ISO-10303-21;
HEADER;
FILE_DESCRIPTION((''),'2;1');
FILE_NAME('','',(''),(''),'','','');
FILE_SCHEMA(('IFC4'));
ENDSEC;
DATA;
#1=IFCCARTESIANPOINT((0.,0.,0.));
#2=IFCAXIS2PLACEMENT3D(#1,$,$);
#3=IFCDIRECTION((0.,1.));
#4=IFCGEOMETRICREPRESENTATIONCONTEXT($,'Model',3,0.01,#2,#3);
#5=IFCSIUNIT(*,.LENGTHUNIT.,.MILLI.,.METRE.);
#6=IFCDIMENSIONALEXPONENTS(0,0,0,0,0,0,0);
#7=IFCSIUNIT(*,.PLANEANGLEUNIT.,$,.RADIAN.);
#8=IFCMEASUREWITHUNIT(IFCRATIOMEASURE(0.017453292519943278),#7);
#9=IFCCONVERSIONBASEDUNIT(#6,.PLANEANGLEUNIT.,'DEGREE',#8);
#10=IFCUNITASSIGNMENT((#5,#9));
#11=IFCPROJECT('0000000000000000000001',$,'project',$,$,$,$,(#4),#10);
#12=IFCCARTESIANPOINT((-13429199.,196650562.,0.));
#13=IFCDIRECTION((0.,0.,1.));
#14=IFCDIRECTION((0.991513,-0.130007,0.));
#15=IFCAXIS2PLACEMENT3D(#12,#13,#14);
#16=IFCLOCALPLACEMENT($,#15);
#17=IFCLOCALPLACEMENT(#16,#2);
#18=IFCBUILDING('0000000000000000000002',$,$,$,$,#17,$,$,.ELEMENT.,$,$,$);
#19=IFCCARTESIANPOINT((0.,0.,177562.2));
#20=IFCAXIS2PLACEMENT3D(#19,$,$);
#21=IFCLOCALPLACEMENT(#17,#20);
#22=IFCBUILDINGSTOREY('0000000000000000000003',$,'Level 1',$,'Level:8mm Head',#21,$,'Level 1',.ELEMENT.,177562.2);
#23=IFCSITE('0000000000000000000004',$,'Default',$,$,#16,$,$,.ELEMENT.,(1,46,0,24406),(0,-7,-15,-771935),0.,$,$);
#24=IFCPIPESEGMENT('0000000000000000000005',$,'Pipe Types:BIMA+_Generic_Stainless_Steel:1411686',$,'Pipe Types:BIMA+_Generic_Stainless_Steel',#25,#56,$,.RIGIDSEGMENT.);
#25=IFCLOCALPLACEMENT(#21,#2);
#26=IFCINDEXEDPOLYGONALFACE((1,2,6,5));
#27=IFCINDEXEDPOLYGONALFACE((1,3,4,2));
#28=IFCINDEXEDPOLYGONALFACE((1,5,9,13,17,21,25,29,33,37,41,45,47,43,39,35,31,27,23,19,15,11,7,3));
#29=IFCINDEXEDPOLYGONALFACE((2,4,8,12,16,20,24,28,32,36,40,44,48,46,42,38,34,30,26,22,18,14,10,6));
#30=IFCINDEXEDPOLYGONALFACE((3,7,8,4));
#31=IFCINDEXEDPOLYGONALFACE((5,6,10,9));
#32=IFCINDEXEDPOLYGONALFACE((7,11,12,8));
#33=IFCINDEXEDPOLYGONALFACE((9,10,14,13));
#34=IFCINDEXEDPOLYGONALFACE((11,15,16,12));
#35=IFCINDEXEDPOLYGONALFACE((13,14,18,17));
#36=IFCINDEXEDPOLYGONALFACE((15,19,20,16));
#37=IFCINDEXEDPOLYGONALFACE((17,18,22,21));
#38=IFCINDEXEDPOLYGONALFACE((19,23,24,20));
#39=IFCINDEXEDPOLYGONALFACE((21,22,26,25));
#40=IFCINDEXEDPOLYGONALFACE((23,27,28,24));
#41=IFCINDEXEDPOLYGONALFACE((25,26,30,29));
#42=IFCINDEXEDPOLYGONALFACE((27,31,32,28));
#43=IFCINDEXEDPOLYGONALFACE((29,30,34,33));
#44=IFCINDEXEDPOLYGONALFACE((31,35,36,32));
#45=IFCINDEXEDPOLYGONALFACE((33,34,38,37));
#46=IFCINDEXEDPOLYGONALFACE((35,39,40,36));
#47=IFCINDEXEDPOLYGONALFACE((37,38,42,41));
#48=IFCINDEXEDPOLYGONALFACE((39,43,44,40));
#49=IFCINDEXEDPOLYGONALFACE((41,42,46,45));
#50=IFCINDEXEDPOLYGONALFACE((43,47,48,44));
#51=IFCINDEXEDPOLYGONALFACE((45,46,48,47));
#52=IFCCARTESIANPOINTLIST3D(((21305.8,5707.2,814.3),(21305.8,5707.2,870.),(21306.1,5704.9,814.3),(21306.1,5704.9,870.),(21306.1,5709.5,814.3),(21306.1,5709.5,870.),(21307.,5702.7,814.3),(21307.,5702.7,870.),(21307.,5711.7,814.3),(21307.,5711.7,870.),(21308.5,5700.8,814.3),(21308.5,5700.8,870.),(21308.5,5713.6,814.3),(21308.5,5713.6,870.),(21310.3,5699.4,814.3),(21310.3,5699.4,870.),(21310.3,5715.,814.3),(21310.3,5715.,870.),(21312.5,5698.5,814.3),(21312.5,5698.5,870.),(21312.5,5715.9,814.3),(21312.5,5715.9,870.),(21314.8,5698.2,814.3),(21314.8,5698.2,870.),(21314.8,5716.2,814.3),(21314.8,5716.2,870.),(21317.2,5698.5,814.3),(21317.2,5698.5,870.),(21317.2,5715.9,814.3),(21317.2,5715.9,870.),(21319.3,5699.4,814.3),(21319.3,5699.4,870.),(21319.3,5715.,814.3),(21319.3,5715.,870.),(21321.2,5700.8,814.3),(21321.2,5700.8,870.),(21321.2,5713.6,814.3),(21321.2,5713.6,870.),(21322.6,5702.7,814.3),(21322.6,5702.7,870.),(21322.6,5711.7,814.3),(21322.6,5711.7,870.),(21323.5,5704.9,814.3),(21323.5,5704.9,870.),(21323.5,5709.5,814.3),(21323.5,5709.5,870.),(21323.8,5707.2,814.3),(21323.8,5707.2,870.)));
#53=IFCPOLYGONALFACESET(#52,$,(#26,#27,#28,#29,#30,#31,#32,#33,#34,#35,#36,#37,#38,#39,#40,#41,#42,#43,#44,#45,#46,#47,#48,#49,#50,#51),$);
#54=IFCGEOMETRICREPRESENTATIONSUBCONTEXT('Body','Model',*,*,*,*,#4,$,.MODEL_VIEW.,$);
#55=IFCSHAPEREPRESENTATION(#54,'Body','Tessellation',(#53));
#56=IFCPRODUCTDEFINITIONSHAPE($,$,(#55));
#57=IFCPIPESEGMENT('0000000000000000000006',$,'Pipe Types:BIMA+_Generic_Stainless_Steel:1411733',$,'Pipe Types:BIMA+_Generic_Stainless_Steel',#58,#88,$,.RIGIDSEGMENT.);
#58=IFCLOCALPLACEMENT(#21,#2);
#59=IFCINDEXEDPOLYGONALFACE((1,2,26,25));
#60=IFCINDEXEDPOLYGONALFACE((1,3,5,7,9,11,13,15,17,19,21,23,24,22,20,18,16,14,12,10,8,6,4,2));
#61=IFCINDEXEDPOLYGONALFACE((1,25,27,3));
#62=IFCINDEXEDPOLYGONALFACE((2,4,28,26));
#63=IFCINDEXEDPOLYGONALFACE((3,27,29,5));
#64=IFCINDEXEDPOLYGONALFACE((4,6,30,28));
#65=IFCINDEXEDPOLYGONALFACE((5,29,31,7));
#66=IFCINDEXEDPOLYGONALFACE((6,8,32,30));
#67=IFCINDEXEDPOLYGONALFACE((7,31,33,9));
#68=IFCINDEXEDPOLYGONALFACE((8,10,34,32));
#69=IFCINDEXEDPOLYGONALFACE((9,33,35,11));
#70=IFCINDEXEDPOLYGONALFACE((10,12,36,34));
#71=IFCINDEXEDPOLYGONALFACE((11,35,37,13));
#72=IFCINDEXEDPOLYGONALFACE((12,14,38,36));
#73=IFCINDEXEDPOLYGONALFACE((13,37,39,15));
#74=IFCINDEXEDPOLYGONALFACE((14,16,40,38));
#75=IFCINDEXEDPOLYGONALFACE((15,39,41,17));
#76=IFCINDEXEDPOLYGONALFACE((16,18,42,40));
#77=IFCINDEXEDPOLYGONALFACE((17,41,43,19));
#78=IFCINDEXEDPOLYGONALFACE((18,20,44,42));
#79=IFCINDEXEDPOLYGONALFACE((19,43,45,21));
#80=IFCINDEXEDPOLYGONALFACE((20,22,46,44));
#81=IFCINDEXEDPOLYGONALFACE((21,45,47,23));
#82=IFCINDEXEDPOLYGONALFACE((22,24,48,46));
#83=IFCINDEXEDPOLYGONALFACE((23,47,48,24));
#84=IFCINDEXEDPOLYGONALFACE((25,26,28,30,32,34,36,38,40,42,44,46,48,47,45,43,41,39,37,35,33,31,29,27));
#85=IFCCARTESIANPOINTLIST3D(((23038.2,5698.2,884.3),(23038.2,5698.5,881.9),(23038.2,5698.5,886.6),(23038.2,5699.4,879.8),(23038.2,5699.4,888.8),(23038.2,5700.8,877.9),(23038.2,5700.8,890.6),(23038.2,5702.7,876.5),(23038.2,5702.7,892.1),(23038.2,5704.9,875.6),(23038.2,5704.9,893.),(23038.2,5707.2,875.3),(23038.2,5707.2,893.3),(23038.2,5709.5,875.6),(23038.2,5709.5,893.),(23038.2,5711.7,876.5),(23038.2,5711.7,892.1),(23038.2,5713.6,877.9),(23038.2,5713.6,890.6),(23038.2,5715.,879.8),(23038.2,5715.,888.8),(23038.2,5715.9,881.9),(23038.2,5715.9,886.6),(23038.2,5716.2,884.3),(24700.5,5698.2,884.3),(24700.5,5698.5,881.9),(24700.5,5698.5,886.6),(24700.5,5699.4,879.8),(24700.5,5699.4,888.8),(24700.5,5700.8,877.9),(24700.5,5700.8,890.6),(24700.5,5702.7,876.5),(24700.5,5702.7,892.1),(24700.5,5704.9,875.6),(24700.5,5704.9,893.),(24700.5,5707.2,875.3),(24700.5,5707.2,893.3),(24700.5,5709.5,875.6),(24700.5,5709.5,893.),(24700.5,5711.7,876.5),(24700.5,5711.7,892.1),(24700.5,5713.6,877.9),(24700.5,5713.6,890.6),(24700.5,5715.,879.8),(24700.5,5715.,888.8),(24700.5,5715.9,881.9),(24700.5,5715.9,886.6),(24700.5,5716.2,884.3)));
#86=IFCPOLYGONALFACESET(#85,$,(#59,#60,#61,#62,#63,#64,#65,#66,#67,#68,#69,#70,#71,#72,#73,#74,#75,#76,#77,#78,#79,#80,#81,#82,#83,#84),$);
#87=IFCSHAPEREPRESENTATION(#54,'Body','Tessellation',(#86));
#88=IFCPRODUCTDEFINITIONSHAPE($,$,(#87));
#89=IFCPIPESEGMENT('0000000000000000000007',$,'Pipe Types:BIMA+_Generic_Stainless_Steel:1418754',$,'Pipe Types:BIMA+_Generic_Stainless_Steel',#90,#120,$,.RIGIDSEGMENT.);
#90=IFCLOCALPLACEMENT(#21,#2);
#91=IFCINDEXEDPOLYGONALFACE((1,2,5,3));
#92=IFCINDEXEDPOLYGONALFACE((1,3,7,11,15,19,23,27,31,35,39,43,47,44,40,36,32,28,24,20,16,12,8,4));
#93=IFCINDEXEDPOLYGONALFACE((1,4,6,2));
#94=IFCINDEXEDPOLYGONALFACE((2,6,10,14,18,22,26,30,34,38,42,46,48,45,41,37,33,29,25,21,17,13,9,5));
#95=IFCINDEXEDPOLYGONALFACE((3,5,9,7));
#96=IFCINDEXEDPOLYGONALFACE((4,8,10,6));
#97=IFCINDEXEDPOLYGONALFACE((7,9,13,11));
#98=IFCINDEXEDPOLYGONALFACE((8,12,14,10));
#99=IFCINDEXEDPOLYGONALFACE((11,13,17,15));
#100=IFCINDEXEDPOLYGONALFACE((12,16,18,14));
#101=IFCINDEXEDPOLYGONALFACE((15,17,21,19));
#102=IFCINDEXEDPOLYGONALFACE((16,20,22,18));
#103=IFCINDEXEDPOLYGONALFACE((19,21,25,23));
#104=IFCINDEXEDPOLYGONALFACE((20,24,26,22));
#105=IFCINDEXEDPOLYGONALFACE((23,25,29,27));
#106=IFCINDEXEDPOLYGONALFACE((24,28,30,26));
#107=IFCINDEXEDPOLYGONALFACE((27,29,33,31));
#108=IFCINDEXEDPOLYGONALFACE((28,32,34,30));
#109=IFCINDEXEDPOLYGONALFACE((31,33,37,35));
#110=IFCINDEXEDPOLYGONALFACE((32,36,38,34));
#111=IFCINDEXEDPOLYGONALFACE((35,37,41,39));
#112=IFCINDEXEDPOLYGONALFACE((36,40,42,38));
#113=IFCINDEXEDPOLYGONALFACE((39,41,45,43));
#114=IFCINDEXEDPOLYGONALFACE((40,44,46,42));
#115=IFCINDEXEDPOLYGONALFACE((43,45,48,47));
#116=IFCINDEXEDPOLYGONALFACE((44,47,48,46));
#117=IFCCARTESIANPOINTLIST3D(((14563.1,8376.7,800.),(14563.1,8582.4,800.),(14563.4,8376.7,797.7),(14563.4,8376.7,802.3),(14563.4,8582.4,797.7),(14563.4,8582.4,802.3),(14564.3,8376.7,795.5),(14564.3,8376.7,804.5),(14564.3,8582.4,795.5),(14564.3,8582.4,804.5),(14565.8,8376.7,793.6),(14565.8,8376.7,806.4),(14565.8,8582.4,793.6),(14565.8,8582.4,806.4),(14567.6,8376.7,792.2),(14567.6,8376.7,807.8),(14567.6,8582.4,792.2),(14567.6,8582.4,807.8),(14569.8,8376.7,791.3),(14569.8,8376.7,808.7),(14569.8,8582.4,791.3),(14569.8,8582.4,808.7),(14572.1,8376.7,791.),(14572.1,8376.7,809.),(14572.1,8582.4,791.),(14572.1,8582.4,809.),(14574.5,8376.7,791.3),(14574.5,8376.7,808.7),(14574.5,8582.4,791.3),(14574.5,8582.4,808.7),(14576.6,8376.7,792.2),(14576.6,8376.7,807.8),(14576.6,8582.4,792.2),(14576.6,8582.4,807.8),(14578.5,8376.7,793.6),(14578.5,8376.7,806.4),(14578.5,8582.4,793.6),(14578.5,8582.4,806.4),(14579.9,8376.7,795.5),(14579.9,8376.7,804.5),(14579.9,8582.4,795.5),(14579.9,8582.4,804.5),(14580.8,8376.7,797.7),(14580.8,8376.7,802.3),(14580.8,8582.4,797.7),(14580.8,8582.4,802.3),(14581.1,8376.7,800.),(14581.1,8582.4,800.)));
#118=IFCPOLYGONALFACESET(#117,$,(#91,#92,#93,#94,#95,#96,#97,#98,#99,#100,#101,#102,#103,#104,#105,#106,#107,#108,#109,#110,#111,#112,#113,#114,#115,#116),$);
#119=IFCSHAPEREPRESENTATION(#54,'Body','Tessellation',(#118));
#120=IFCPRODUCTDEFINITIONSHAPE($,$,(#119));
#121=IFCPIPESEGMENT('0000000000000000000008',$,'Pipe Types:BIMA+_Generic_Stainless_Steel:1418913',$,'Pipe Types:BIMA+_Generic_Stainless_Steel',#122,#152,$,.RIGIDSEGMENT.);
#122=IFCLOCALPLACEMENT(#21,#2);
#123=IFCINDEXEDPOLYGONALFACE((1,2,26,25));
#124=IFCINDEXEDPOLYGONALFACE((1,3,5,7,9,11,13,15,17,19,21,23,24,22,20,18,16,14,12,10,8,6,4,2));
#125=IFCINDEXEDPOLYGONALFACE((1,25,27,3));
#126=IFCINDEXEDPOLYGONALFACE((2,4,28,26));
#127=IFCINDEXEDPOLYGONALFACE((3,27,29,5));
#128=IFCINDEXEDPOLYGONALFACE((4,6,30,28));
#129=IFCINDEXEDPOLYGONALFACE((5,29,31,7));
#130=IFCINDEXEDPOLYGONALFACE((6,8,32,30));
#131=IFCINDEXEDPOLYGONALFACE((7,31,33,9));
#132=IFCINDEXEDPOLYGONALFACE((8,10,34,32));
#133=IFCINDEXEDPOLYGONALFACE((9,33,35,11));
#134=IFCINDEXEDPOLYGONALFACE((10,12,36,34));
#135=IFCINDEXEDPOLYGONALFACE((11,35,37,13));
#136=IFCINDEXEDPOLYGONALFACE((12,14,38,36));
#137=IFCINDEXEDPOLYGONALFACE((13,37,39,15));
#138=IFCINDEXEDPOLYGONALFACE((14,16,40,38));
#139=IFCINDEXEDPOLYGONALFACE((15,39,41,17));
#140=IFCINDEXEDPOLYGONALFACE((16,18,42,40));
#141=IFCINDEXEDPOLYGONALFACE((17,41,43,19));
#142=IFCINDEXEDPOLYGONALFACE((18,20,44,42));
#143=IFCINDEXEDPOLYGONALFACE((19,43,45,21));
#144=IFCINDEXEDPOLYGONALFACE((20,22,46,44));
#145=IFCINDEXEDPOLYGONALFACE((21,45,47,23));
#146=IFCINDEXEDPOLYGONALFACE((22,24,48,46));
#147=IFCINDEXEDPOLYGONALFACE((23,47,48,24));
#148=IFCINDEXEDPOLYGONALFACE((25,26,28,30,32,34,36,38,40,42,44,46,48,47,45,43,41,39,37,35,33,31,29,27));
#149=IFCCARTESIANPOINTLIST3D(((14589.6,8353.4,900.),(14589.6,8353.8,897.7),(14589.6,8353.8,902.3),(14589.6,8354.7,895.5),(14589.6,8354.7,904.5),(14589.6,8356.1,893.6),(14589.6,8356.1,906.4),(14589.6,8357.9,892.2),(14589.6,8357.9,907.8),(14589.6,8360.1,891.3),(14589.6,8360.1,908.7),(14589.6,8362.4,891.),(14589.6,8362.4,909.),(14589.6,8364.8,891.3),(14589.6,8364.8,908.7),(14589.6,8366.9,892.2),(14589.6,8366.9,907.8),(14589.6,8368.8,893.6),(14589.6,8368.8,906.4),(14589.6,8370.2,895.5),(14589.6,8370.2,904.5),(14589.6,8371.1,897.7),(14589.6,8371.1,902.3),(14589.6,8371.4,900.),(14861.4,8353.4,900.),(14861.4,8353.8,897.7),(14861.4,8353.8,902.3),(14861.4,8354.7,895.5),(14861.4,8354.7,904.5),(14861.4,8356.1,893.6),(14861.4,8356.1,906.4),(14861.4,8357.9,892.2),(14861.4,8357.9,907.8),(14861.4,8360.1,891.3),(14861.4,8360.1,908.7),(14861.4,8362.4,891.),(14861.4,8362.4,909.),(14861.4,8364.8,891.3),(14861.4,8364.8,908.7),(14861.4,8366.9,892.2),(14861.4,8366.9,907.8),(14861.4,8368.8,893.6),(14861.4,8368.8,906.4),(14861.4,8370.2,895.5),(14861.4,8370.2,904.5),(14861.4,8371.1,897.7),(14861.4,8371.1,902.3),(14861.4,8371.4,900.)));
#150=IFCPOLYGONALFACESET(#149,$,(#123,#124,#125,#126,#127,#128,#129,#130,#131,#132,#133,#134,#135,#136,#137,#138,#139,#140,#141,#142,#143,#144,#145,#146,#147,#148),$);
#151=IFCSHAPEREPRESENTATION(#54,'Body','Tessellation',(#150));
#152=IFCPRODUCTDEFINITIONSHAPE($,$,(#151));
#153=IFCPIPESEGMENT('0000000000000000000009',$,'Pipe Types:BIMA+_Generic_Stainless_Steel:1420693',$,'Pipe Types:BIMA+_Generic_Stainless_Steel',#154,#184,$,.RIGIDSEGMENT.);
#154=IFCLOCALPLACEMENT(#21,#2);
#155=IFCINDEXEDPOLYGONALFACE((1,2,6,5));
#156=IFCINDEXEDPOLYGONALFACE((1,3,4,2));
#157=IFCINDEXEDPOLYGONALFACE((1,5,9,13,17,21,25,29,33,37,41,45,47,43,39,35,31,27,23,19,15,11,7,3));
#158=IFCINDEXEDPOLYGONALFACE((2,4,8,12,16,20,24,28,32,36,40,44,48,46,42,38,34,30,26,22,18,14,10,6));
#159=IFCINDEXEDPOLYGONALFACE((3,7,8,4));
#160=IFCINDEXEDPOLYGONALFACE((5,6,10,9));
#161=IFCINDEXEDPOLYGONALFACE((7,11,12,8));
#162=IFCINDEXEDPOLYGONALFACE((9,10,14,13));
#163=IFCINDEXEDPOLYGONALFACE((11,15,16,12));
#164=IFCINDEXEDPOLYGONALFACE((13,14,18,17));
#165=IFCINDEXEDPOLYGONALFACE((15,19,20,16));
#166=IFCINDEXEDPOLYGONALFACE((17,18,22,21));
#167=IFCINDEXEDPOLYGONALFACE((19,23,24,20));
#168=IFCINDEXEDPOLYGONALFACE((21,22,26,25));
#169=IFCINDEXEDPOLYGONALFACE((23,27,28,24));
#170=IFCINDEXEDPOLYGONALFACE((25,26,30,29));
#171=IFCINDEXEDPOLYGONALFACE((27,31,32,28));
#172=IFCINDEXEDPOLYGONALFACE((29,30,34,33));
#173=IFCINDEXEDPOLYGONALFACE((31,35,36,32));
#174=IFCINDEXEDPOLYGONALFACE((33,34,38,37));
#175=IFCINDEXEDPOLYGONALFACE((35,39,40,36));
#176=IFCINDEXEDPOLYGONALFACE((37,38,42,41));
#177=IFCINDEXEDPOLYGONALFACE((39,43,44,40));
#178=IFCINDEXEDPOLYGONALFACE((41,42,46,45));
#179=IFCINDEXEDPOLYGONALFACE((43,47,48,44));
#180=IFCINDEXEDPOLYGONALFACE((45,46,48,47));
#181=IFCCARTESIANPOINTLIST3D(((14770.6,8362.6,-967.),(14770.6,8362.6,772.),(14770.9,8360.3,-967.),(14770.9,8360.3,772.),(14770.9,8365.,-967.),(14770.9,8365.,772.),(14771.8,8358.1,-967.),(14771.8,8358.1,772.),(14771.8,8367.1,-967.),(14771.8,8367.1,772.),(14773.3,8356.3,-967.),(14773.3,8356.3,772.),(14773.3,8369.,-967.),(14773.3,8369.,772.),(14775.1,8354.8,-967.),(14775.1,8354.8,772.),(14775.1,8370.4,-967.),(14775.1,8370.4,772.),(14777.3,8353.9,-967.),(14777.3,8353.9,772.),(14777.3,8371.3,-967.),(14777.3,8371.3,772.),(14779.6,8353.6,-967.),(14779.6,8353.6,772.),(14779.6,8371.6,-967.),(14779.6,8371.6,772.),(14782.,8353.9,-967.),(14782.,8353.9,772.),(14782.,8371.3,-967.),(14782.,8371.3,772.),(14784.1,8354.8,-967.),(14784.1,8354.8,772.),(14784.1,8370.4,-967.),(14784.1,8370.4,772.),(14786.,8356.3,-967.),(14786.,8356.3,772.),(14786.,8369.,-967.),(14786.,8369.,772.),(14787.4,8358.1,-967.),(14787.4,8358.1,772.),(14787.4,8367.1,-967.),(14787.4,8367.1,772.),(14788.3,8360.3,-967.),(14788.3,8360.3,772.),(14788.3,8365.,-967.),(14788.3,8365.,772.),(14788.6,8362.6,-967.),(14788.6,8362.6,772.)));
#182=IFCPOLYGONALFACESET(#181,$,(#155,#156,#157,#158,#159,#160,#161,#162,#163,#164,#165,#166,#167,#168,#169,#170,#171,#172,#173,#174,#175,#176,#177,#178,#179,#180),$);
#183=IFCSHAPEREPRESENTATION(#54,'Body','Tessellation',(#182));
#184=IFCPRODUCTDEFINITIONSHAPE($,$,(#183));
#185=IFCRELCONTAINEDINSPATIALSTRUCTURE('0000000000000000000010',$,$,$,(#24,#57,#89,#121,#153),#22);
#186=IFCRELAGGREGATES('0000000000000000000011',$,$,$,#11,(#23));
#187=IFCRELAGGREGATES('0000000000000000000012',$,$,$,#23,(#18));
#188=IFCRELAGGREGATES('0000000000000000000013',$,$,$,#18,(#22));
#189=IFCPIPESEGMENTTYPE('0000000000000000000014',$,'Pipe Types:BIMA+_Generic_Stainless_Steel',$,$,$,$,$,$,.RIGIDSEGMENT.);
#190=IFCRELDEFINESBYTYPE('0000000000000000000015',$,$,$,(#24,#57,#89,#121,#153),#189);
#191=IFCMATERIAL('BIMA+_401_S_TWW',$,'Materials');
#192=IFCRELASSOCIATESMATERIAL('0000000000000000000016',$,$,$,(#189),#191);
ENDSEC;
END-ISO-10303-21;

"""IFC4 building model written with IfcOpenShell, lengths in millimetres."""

from ifc_helpers import new_model, entity, si_unit, converted_unit, direction, frame, origin, place, context, subcontext, project, spatial, arc, indexed_curve, outline, extrude, material, type_object, element, save


model = new_model("IFC4")

# Units and contexts
model_context = context("Model", 3, precision=0.01, world=origin(), true_north=direction((0.0, 1.0)))
body_context = subcontext(model_context, "Body", "Model", "MODEL_VIEW")
ifc_project = project(units=[si_unit("LENGTHUNIT", "METRE", prefix="MILLI"), converted_unit("PLANEANGLEUNIT", "DEGREE", entity("IfcRatioMeasure", 0.017453292519943278), si_unit("PLANEANGLEUNIT", "RADIAN"), dimensions=[0, 0, 0, 0, 0, 0, 0])], contexts=[model_context])

# Site, building, storey
site_placement = place(None, frame((-13429199.0, 196650562.0, 0.0), z_axis=(0.0, 0.0, 1.0), x_axis=(0.991513, -0.130007, 0.0)))
site = spatial("IfcSite", under=ifc_project, at=site_placement, Name="Default", CompositionType="ELEMENT", RefLatitude=(1, 46, 0, 24406), RefLongitude=(0, -7, -15, -771935), RefElevation=0.0)
building_placement = place(site_placement, origin())
building = spatial("IfcBuilding", under=site, at=building_placement, CompositionType="ELEMENT")
storey_placement = place(building_placement, frame((0.0, 0.0, 177562.2)))
storey = spatial("IfcBuildingStorey", under=building, at=storey_placement, Name="Level 1", ObjectType="Level:8mm Head", LongName="Level 1", CompositionType="ELEMENT", Elevation=177562.2)

# Pipe segments
ifc_material_1 = material(Name="BIMA+_401_S_TWW", Category="Materials")
pipe_segment_type_1 = type_object("IfcPipeSegmentType", Name="Pipe Types:BIMA+_Generic_Stainless_Steel", PredefinedType="RIGIDSEGMENT", material=ifc_material_1)
pipe_segment_1_placement = place(storey_placement, frame((21304.2, 5696.6, 814.3)))
element("IfcPipeSegment", 1, at=pipe_segment_1_placement, inside=storey, type_object=pipe_segment_type_1, Name="Pipe Types:BIMA+_Generic_Stainless_Steel:1411686", ObjectType="Pipe Types:BIMA+_Generic_Stainless_Steel", PredefinedType="RIGIDSEGMENT", context=body_context, shape_type="SweptSolid", body=[
    extrude(outline(indexed_curve([(9.0, 0.0), (6.4, 6.4), (0.0, 9.0), (-6.4, 6.4), (-9.0, 0.0), (-6.4, -6.4), (0.0, -9.0), (6.4, -6.4)], segments=[arc(1, 2, 3), arc(3, 4, 5), arc(5, 6, 7), arc(7, 8, 1)], self_intersect=False)), frame((10.6, 10.6, 0.0), z_axis=(0.0, 0.0, 1.0), x_axis=(-1.0, 0.0, 0.0)), (0.0, 0.0, 1.0), 55.7),
])
pipe_segment_2_placement = place(storey_placement, frame((23038.2, 5696.6, 873.7)))
element("IfcPipeSegment", 2, at=pipe_segment_2_placement, inside=storey, type_object=pipe_segment_type_1, Name="Pipe Types:BIMA+_Generic_Stainless_Steel:1411733", ObjectType="Pipe Types:BIMA+_Generic_Stainless_Steel", PredefinedType="RIGIDSEGMENT", context=body_context, shape_type="SweptSolid", body=[
    extrude(outline(indexed_curve([(9.0, 0.0), (6.4, 6.4), (0.0, 9.0), (-6.4, 6.4), (-9.0, 0.0), (-6.4, -6.4), (0.0, -9.0), (6.4, -6.4)], segments=[arc(1, 2, 3), arc(3, 4, 5), arc(5, 6, 7), arc(7, 8, 1)], self_intersect=False)), frame((0.0, 10.6, 10.6), z_axis=(1.0, 0.0, 0.0), x_axis=(0.0, 1.0, 0.0)), (0.0, 0.0, 1.0), 1662.4),
])
pipe_segment_3_placement = place(storey_placement, frame((14561.5, 8376.7, 789.4)))
element("IfcPipeSegment", 3, at=pipe_segment_3_placement, inside=storey, type_object=pipe_segment_type_1, Name="Pipe Types:BIMA+_Generic_Stainless_Steel:1418754", ObjectType="Pipe Types:BIMA+_Generic_Stainless_Steel", PredefinedType="RIGIDSEGMENT", context=body_context, shape_type="SweptSolid", body=[
    extrude(outline(indexed_curve([(9.0, 0.0), (6.4, 6.4), (0.0, 9.0), (-6.4, 6.4), (-9.0, 0.0), (-6.4, -6.4), (0.0, -9.0), (6.4, -6.4)], segments=[arc(1, 2, 3), arc(3, 4, 5), arc(5, 6, 7), arc(7, 8, 1)], self_intersect=False)), frame((10.6, 0.0, 10.6), z_axis=(0.0, 1.0, 0.0), x_axis=(1.0, 0.0, 0.0)), (0.0, 0.0, 1.0), 205.7),
])
pipe_segment_4_placement = place(storey_placement, frame((14589.6, 8351.9, 889.4)))
element("IfcPipeSegment", 4, at=pipe_segment_4_placement, inside=storey, type_object=pipe_segment_type_1, Name="Pipe Types:BIMA+_Generic_Stainless_Steel:1418913", ObjectType="Pipe Types:BIMA+_Generic_Stainless_Steel", PredefinedType="RIGIDSEGMENT", context=body_context, shape_type="SweptSolid", body=[
    extrude(outline(indexed_curve([(9.0, 0.0), (6.4, 6.4), (0.0, 9.0), (-6.4, 6.4), (-9.0, 0.0), (-6.4, -6.4), (0.0, -9.0), (6.4, -6.4)], segments=[arc(1, 2, 3), arc(3, 4, 5), arc(5, 6, 7), arc(7, 8, 1)], self_intersect=False)), frame((0.0, 10.6, 10.6), z_axis=(1.0, 0.0, 0.0), x_axis=(0.0, 1.0, 0.0)), (0.0, 0.0, 1.0), 271.8),
])
pipe_segment_5_placement = place(storey_placement, frame((14769.0, 8352.0, 772.0)))
element("IfcPipeSegment", 5, at=pipe_segment_5_placement, inside=storey, type_object=pipe_segment_type_1, Name="Pipe Types:BIMA+_Generic_Stainless_Steel:1420693", ObjectType="Pipe Types:BIMA+_Generic_Stainless_Steel", PredefinedType="RIGIDSEGMENT", context=body_context, shape_type="SweptSolid", body=[
    extrude(outline(indexed_curve([(9.0, 0.0), (6.4, 6.4), (0.0, 9.0), (-6.4, 6.4), (-9.0, 0.0), (-6.4, -6.4), (0.0, -9.0), (6.4, -6.4)], segments=[arc(1, 2, 3), arc(3, 4, 5), arc(5, 6, 7), arc(7, 8, 1)], self_intersect=False)), frame((10.6, 10.6, -1739.0)), (0.0, 0.0, 1.0), 1739.0),
])

save(model, "model.ifc")
